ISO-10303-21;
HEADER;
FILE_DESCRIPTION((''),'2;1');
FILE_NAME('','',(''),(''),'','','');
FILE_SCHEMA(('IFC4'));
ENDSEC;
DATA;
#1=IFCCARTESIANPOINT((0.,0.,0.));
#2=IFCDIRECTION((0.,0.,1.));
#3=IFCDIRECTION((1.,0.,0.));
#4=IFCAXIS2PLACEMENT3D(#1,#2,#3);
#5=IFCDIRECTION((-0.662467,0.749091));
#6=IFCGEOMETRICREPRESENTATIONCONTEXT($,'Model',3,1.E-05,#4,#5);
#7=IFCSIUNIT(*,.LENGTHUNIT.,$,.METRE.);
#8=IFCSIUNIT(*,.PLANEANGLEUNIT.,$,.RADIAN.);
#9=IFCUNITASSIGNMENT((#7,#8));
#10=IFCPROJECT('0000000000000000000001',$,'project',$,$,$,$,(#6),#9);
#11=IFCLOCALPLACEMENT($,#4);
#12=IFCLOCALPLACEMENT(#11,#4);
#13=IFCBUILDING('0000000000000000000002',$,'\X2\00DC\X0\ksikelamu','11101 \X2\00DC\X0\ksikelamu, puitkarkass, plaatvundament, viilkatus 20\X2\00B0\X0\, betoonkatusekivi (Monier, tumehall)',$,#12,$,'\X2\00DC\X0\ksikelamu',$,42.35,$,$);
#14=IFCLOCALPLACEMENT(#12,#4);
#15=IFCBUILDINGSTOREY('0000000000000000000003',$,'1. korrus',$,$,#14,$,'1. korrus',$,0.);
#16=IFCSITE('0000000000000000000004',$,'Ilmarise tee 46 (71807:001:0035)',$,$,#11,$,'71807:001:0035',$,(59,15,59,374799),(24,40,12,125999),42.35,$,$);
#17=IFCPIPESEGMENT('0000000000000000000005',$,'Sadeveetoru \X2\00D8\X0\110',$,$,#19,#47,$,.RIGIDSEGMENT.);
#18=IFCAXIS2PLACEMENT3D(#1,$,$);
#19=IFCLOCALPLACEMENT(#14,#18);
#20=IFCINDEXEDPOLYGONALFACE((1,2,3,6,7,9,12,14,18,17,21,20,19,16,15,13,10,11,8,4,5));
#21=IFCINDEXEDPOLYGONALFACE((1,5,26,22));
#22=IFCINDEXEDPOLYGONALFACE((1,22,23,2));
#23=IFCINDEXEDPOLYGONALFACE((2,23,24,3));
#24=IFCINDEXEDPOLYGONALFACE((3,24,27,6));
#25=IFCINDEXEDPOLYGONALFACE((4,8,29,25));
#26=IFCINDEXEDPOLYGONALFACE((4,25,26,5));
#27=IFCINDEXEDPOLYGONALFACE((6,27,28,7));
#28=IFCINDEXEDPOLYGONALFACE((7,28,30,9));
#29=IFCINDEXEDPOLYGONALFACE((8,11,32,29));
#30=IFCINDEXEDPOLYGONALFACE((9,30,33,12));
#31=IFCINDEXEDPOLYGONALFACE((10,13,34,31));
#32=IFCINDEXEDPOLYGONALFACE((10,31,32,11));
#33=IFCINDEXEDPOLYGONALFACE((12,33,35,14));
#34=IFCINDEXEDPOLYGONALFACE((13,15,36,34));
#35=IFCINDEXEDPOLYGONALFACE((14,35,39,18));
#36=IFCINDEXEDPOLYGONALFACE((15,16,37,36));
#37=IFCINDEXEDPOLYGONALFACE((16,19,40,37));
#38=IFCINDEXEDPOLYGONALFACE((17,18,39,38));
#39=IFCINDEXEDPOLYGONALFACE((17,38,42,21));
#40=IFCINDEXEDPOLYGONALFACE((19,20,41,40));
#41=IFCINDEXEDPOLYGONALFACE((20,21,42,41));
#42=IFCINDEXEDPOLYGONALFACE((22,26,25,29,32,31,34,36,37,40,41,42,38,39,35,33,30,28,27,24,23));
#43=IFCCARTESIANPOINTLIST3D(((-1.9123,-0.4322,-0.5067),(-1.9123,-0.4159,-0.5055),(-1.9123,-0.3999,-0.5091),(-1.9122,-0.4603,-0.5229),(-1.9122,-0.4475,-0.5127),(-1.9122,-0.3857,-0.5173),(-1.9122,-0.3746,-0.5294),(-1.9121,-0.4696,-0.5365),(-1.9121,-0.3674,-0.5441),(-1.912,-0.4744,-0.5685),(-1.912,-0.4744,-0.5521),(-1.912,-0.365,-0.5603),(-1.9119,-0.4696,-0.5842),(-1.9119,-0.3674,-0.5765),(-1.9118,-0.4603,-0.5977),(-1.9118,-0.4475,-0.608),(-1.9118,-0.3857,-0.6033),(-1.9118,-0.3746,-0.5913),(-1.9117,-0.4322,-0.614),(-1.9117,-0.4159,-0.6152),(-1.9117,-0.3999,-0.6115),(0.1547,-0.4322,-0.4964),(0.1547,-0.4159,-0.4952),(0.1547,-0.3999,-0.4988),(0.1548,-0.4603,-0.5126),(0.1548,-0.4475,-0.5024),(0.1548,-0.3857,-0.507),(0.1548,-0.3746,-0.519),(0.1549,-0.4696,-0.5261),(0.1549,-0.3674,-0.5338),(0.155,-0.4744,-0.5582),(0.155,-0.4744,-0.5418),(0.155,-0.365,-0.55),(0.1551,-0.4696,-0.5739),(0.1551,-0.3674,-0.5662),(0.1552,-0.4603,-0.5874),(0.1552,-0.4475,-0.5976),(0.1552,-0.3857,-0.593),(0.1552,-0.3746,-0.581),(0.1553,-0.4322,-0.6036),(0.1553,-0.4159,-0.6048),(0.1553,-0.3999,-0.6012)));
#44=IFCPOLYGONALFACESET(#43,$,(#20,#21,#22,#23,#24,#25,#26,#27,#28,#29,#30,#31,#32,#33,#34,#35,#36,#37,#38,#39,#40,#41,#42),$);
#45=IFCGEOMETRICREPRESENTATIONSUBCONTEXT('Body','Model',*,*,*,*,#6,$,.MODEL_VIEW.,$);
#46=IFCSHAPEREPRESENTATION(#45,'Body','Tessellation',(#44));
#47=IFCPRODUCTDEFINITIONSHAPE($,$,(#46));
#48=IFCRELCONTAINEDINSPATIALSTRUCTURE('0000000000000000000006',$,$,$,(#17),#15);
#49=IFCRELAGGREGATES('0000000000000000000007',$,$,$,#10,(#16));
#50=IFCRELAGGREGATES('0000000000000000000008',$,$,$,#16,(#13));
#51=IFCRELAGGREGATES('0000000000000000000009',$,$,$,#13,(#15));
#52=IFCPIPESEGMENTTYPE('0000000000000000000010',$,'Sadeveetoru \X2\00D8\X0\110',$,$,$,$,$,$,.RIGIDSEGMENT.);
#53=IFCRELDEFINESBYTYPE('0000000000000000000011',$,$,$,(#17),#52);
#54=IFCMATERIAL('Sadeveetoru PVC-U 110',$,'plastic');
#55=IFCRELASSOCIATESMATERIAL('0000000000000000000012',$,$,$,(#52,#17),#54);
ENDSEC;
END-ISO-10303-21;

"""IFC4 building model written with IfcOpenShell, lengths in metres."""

from ifc_helpers import new_model, si_unit, direction, frame, origin_with_axes, place, context, subcontext, project, spatial, circle, extrude, material, type_object, element, save


model = new_model("IFC4")

# Units and contexts
model_context = context("Model", 3, precision=1e-05, world=origin_with_axes(), true_north=direction((-0.662467, 0.749091)))
body_context = subcontext(model_context, "Body", "Model", "MODEL_VIEW")
ifc_project = project(units=[si_unit("LENGTHUNIT", "METRE"), si_unit("PLANEANGLEUNIT", "RADIAN")], contexts=[model_context])

# Site, building, storey
site_placement = place(None, origin_with_axes())
site = spatial("IfcSite", under=ifc_project, at=site_placement, Name="Ilmarise tee 46 (71807:001:0035)", LongName="71807:001:0035", RefLatitude=(59, 15, 59, 374799), RefLongitude=(24, 40, 12, 125999), RefElevation=42.35)
building_placement = place(site_placement, origin_with_axes())
building = spatial("IfcBuilding", under=site, at=building_placement, Name="Üksikelamu", Description="11101 Üksikelamu, puitkarkass, plaatvundament, viilkatus 20°, betoonkatusekivi (Monier, tumehall)", LongName="Üksikelamu", ElevationOfRefHeight=42.35)
storey_placement = place(building_placement, origin_with_axes())
storey = spatial("IfcBuildingStorey", under=building, at=storey_placement, Name="1. korrus", LongName="1. korrus", Elevation=0.0)

# Pipe segment
ifc_material_1 = material(Name="Sadeveetoru PVC-U 110", Category="plastic")
pipe_segment_type = type_object("IfcPipeSegmentType", Name="Sadeveetoru Ø110", PredefinedType="RIGIDSEGMENT", material=ifc_material_1)
pipe_segment_placement = place(storey_placement, frame((0.155, -0.42, -0.55), z_axis=(-0.999988, 0.0, -0.005), x_axis=(0.0, 1.0, 0.0)))
element("IfcPipeSegment", 1, at=pipe_segment_placement, inside=storey, type_object=pipe_segment_type, material=ifc_material_1, Name="Sadeveetoru Ø110", PredefinedType="RIGIDSEGMENT", context=body_context, shape_type="SweptSolid", body=[
    extrude(circle(Radius=0.055), origin_with_axes(), (0.0, 0.0, 1.0), 2.067),
])

save(model, "model.ifc")
